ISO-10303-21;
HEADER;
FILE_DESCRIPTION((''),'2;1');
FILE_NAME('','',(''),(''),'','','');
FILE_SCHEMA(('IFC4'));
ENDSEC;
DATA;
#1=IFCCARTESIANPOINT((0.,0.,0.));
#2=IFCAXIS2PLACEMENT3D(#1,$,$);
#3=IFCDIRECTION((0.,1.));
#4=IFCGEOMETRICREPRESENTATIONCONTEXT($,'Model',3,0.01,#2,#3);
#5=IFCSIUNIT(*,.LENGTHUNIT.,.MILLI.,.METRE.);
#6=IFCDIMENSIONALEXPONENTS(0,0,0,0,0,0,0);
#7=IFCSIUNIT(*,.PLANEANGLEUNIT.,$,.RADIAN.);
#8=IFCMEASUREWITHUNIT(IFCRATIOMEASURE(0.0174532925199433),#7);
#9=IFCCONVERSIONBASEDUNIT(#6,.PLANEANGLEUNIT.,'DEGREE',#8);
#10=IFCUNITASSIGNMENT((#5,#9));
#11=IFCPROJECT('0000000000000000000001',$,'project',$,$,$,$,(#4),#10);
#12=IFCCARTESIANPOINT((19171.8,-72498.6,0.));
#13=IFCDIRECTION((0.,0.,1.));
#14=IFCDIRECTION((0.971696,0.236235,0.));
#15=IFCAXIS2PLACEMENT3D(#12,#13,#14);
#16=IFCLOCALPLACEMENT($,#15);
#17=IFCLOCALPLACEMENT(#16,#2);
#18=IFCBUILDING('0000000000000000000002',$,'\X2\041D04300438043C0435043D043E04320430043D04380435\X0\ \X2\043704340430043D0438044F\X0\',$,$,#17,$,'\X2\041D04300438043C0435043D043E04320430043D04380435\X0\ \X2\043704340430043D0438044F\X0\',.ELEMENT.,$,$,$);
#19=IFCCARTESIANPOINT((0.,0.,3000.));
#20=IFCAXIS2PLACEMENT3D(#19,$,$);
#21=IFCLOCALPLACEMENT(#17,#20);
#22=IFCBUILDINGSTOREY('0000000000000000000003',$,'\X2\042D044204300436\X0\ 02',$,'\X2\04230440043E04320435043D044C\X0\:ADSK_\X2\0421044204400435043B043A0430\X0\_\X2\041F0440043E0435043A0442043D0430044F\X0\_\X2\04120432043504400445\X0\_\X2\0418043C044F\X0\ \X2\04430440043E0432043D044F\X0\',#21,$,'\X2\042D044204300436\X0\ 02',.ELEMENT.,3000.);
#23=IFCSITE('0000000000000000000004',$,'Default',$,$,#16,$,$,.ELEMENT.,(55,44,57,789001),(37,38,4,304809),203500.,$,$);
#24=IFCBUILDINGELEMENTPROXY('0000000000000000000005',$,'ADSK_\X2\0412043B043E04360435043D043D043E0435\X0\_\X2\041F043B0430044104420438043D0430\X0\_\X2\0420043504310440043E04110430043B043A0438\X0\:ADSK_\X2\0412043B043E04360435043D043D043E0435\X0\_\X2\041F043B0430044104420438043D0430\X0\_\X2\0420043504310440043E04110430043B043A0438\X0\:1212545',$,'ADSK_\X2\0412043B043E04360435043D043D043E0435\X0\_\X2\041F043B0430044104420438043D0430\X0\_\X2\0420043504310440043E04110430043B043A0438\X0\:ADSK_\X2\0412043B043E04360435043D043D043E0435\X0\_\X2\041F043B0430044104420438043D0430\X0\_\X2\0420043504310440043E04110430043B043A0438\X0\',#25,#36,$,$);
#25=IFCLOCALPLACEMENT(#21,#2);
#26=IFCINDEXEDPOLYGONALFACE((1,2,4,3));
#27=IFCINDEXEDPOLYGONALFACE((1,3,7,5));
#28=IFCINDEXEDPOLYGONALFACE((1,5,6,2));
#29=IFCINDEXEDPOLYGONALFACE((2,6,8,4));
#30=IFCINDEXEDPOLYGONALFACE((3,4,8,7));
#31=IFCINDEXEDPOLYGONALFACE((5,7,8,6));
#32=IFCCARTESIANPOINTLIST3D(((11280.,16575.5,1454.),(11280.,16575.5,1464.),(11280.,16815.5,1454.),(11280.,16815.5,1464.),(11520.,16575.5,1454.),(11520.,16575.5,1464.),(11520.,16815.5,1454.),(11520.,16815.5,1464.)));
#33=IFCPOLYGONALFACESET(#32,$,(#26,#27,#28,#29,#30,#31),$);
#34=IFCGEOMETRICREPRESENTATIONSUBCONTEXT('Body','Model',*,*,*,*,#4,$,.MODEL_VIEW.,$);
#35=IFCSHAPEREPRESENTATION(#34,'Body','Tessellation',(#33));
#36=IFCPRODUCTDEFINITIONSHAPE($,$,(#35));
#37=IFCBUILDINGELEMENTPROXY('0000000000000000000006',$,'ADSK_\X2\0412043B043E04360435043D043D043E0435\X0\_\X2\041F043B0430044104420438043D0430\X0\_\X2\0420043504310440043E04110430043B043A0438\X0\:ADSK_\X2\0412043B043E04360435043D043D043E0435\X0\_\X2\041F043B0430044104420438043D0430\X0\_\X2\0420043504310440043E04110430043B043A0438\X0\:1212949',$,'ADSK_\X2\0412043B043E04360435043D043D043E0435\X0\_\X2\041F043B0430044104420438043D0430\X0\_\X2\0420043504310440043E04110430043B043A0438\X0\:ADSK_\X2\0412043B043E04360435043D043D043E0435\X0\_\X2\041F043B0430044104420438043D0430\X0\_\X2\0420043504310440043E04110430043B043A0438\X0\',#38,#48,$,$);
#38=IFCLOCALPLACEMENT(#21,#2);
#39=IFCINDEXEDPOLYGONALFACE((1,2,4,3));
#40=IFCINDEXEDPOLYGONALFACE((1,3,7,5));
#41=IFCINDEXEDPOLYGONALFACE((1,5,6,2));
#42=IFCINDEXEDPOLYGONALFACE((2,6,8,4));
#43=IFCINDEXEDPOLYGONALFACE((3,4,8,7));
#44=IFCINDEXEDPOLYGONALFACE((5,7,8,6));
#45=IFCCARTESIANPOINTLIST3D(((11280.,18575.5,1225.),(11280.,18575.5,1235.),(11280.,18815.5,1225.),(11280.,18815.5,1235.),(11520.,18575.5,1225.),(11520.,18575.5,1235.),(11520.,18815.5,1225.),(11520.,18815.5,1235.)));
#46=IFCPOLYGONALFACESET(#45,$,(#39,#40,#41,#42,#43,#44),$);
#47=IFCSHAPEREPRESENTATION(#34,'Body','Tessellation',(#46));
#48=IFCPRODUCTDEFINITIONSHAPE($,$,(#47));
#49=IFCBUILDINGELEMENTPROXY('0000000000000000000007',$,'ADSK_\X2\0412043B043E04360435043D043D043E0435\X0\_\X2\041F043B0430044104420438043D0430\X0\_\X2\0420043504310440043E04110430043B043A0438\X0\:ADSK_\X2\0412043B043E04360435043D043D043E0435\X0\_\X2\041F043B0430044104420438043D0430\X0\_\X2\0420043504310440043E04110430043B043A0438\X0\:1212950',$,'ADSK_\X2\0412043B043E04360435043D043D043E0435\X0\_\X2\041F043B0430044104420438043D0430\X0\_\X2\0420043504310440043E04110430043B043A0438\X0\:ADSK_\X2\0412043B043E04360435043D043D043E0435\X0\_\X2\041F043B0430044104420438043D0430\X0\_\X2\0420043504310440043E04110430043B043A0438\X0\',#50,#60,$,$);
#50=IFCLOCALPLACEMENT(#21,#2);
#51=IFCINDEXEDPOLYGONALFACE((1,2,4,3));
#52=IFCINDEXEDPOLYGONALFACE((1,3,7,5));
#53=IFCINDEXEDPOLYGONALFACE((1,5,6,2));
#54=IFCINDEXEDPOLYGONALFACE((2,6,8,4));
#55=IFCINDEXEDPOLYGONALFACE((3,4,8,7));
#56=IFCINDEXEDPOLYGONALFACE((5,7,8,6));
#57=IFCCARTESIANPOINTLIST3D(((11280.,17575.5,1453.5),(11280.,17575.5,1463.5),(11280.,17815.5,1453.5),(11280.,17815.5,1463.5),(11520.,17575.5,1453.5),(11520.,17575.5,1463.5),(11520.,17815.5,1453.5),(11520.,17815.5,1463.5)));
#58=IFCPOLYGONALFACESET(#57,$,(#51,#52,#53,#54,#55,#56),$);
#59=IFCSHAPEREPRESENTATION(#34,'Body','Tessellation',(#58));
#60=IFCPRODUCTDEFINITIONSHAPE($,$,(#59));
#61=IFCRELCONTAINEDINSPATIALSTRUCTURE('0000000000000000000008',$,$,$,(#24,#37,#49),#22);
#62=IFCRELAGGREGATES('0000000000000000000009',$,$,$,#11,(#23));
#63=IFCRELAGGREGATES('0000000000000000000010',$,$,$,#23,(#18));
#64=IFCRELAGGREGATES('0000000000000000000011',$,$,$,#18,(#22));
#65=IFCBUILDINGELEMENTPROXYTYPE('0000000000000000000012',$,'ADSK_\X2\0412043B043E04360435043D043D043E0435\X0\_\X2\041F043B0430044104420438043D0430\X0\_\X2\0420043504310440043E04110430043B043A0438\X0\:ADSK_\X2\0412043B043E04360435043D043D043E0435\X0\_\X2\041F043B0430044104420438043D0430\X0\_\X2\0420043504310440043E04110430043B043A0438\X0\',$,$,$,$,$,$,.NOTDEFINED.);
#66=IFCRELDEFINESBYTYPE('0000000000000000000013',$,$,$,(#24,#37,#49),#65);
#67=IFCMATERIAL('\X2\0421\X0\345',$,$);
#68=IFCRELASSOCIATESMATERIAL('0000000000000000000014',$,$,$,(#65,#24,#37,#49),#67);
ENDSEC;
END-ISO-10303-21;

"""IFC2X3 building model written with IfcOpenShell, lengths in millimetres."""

from ifc_helpers import new_model, entity, si_unit, converted_unit, direction, frame, origin, origin_2d_with_axis, place, context, subcontext, project, spatial, rectangle, extrude, source, transform, mapped, material, type_object, type_shapes, element, save


model = new_model("IFC2X3")

# Units and contexts
model_context = context("Model", 3, precision=0.01, world=origin(), true_north=direction((0.0, 1.0)))
body_context = subcontext(model_context, "Body", "Model", "MODEL_VIEW")
ifc_project = project(units=[si_unit("LENGTHUNIT", "METRE", prefix="MILLI"), converted_unit("PLANEANGLEUNIT", "DEGREE", entity("IfcRatioMeasure", 0.0174532925199433), si_unit("PLANEANGLEUNIT", "RADIAN"), dimensions=[0, 0, 0, 0, 0, 0, 0])], contexts=[model_context])

# Site, building, storey
site_placement = place(None, frame((19171.8, -72498.6, 0.0), z_axis=(0.0, 0.0, 1.0), x_axis=(0.971696, 0.236235, 0.0)))
site = spatial("IfcSite", under=ifc_project, at=site_placement, Name="Default", CompositionType="ELEMENT", RefLatitude=(55, 44, 57, 789001), RefLongitude=(37, 38, 4, 304809), RefElevation=203500.0)
building_placement = place(site_placement, origin())
building = spatial("IfcBuilding", under=site, at=building_placement, Name="Наименование здания", LongName="Наименование здания", CompositionType="ELEMENT")
storey_placement = place(building_placement, frame((0.0, 0.0, 3000.0)))
storey = spatial("IfcBuildingStorey", under=building, at=storey_placement, Name="Этаж 02", ObjectType="Уровень:ADSK_Стрелка_Проектная_Вверх_Имя уровня", LongName="Этаж 02", CompositionType="ELEMENT", Elevation=3000.0)

# Building element proxies
ifc_material_1 = material(Name="С345")
building_element_proxy_type = type_object("IfcBuildingElementProxyType", Name="ADSK_Вложенное_Пластина_РеброБалки:ADSK_Вложенное_Пластина_РеброБалки", PredefinedType="NOTDEFINED", material=ifc_material_1)
shared_shape = source(origin(), body_context, "Body", "SweptSolid", [
    extrude(rectangle(XDim=10.0, YDim=240.0, at=origin_2d_with_axis()), frame((0.0, 0.0, -120.0), z_axis=(0.0, 0.0, 1.0), x_axis=(0.0, 1.0, 0.0)), (0.0, 0.0, 1.0), 240.0),
])
type_shapes(building_element_proxy_type, [shared_shape])
for number, where, z_axis, x_axis, name in (
    (1, (11400.0, 16695.5, 1459.0), (0.0, 1.0, 0.0), (1.0, 0.0, 0.0), "ADSK_Вложенное_Пластина_РеброБалки:ADSK_Вложенное_Пластина_РеброБалки:1212545"),
    (2, (11400.0, 18695.5, 1230.0), (0.0, 1.0, 0.0), (1.0, 0.0, 0.0), "ADSK_Вложенное_Пластина_РеброБалки:ADSK_Вложенное_Пластина_РеброБалки:1212949"),
    (3, (11400.0, 17695.5, 1458.5), (0.0, 1.0, 0.0), (1.0, 0.0, 0.0), "ADSK_Вложенное_Пластина_РеброБалки:ADSK_Вложенное_Пластина_РеброБалки:1212950"),
):
    element("IfcBuildingElementProxy", number, at=place(storey_placement, frame(where, z_axis=z_axis, x_axis=x_axis)), inside=storey, type_object=building_element_proxy_type, material=ifc_material_1, Name=name, ObjectType="ADSK_Вложенное_Пластина_РеброБалки:ADSK_Вложенное_Пластина_РеброБалки", context=body_context, shape_type="MappedRepresentation", body=[
        mapped(shared_shape, transform((0.0, 0.0, 0.0), scale=1.0)),
    ])

save(model, "model.ifc")
